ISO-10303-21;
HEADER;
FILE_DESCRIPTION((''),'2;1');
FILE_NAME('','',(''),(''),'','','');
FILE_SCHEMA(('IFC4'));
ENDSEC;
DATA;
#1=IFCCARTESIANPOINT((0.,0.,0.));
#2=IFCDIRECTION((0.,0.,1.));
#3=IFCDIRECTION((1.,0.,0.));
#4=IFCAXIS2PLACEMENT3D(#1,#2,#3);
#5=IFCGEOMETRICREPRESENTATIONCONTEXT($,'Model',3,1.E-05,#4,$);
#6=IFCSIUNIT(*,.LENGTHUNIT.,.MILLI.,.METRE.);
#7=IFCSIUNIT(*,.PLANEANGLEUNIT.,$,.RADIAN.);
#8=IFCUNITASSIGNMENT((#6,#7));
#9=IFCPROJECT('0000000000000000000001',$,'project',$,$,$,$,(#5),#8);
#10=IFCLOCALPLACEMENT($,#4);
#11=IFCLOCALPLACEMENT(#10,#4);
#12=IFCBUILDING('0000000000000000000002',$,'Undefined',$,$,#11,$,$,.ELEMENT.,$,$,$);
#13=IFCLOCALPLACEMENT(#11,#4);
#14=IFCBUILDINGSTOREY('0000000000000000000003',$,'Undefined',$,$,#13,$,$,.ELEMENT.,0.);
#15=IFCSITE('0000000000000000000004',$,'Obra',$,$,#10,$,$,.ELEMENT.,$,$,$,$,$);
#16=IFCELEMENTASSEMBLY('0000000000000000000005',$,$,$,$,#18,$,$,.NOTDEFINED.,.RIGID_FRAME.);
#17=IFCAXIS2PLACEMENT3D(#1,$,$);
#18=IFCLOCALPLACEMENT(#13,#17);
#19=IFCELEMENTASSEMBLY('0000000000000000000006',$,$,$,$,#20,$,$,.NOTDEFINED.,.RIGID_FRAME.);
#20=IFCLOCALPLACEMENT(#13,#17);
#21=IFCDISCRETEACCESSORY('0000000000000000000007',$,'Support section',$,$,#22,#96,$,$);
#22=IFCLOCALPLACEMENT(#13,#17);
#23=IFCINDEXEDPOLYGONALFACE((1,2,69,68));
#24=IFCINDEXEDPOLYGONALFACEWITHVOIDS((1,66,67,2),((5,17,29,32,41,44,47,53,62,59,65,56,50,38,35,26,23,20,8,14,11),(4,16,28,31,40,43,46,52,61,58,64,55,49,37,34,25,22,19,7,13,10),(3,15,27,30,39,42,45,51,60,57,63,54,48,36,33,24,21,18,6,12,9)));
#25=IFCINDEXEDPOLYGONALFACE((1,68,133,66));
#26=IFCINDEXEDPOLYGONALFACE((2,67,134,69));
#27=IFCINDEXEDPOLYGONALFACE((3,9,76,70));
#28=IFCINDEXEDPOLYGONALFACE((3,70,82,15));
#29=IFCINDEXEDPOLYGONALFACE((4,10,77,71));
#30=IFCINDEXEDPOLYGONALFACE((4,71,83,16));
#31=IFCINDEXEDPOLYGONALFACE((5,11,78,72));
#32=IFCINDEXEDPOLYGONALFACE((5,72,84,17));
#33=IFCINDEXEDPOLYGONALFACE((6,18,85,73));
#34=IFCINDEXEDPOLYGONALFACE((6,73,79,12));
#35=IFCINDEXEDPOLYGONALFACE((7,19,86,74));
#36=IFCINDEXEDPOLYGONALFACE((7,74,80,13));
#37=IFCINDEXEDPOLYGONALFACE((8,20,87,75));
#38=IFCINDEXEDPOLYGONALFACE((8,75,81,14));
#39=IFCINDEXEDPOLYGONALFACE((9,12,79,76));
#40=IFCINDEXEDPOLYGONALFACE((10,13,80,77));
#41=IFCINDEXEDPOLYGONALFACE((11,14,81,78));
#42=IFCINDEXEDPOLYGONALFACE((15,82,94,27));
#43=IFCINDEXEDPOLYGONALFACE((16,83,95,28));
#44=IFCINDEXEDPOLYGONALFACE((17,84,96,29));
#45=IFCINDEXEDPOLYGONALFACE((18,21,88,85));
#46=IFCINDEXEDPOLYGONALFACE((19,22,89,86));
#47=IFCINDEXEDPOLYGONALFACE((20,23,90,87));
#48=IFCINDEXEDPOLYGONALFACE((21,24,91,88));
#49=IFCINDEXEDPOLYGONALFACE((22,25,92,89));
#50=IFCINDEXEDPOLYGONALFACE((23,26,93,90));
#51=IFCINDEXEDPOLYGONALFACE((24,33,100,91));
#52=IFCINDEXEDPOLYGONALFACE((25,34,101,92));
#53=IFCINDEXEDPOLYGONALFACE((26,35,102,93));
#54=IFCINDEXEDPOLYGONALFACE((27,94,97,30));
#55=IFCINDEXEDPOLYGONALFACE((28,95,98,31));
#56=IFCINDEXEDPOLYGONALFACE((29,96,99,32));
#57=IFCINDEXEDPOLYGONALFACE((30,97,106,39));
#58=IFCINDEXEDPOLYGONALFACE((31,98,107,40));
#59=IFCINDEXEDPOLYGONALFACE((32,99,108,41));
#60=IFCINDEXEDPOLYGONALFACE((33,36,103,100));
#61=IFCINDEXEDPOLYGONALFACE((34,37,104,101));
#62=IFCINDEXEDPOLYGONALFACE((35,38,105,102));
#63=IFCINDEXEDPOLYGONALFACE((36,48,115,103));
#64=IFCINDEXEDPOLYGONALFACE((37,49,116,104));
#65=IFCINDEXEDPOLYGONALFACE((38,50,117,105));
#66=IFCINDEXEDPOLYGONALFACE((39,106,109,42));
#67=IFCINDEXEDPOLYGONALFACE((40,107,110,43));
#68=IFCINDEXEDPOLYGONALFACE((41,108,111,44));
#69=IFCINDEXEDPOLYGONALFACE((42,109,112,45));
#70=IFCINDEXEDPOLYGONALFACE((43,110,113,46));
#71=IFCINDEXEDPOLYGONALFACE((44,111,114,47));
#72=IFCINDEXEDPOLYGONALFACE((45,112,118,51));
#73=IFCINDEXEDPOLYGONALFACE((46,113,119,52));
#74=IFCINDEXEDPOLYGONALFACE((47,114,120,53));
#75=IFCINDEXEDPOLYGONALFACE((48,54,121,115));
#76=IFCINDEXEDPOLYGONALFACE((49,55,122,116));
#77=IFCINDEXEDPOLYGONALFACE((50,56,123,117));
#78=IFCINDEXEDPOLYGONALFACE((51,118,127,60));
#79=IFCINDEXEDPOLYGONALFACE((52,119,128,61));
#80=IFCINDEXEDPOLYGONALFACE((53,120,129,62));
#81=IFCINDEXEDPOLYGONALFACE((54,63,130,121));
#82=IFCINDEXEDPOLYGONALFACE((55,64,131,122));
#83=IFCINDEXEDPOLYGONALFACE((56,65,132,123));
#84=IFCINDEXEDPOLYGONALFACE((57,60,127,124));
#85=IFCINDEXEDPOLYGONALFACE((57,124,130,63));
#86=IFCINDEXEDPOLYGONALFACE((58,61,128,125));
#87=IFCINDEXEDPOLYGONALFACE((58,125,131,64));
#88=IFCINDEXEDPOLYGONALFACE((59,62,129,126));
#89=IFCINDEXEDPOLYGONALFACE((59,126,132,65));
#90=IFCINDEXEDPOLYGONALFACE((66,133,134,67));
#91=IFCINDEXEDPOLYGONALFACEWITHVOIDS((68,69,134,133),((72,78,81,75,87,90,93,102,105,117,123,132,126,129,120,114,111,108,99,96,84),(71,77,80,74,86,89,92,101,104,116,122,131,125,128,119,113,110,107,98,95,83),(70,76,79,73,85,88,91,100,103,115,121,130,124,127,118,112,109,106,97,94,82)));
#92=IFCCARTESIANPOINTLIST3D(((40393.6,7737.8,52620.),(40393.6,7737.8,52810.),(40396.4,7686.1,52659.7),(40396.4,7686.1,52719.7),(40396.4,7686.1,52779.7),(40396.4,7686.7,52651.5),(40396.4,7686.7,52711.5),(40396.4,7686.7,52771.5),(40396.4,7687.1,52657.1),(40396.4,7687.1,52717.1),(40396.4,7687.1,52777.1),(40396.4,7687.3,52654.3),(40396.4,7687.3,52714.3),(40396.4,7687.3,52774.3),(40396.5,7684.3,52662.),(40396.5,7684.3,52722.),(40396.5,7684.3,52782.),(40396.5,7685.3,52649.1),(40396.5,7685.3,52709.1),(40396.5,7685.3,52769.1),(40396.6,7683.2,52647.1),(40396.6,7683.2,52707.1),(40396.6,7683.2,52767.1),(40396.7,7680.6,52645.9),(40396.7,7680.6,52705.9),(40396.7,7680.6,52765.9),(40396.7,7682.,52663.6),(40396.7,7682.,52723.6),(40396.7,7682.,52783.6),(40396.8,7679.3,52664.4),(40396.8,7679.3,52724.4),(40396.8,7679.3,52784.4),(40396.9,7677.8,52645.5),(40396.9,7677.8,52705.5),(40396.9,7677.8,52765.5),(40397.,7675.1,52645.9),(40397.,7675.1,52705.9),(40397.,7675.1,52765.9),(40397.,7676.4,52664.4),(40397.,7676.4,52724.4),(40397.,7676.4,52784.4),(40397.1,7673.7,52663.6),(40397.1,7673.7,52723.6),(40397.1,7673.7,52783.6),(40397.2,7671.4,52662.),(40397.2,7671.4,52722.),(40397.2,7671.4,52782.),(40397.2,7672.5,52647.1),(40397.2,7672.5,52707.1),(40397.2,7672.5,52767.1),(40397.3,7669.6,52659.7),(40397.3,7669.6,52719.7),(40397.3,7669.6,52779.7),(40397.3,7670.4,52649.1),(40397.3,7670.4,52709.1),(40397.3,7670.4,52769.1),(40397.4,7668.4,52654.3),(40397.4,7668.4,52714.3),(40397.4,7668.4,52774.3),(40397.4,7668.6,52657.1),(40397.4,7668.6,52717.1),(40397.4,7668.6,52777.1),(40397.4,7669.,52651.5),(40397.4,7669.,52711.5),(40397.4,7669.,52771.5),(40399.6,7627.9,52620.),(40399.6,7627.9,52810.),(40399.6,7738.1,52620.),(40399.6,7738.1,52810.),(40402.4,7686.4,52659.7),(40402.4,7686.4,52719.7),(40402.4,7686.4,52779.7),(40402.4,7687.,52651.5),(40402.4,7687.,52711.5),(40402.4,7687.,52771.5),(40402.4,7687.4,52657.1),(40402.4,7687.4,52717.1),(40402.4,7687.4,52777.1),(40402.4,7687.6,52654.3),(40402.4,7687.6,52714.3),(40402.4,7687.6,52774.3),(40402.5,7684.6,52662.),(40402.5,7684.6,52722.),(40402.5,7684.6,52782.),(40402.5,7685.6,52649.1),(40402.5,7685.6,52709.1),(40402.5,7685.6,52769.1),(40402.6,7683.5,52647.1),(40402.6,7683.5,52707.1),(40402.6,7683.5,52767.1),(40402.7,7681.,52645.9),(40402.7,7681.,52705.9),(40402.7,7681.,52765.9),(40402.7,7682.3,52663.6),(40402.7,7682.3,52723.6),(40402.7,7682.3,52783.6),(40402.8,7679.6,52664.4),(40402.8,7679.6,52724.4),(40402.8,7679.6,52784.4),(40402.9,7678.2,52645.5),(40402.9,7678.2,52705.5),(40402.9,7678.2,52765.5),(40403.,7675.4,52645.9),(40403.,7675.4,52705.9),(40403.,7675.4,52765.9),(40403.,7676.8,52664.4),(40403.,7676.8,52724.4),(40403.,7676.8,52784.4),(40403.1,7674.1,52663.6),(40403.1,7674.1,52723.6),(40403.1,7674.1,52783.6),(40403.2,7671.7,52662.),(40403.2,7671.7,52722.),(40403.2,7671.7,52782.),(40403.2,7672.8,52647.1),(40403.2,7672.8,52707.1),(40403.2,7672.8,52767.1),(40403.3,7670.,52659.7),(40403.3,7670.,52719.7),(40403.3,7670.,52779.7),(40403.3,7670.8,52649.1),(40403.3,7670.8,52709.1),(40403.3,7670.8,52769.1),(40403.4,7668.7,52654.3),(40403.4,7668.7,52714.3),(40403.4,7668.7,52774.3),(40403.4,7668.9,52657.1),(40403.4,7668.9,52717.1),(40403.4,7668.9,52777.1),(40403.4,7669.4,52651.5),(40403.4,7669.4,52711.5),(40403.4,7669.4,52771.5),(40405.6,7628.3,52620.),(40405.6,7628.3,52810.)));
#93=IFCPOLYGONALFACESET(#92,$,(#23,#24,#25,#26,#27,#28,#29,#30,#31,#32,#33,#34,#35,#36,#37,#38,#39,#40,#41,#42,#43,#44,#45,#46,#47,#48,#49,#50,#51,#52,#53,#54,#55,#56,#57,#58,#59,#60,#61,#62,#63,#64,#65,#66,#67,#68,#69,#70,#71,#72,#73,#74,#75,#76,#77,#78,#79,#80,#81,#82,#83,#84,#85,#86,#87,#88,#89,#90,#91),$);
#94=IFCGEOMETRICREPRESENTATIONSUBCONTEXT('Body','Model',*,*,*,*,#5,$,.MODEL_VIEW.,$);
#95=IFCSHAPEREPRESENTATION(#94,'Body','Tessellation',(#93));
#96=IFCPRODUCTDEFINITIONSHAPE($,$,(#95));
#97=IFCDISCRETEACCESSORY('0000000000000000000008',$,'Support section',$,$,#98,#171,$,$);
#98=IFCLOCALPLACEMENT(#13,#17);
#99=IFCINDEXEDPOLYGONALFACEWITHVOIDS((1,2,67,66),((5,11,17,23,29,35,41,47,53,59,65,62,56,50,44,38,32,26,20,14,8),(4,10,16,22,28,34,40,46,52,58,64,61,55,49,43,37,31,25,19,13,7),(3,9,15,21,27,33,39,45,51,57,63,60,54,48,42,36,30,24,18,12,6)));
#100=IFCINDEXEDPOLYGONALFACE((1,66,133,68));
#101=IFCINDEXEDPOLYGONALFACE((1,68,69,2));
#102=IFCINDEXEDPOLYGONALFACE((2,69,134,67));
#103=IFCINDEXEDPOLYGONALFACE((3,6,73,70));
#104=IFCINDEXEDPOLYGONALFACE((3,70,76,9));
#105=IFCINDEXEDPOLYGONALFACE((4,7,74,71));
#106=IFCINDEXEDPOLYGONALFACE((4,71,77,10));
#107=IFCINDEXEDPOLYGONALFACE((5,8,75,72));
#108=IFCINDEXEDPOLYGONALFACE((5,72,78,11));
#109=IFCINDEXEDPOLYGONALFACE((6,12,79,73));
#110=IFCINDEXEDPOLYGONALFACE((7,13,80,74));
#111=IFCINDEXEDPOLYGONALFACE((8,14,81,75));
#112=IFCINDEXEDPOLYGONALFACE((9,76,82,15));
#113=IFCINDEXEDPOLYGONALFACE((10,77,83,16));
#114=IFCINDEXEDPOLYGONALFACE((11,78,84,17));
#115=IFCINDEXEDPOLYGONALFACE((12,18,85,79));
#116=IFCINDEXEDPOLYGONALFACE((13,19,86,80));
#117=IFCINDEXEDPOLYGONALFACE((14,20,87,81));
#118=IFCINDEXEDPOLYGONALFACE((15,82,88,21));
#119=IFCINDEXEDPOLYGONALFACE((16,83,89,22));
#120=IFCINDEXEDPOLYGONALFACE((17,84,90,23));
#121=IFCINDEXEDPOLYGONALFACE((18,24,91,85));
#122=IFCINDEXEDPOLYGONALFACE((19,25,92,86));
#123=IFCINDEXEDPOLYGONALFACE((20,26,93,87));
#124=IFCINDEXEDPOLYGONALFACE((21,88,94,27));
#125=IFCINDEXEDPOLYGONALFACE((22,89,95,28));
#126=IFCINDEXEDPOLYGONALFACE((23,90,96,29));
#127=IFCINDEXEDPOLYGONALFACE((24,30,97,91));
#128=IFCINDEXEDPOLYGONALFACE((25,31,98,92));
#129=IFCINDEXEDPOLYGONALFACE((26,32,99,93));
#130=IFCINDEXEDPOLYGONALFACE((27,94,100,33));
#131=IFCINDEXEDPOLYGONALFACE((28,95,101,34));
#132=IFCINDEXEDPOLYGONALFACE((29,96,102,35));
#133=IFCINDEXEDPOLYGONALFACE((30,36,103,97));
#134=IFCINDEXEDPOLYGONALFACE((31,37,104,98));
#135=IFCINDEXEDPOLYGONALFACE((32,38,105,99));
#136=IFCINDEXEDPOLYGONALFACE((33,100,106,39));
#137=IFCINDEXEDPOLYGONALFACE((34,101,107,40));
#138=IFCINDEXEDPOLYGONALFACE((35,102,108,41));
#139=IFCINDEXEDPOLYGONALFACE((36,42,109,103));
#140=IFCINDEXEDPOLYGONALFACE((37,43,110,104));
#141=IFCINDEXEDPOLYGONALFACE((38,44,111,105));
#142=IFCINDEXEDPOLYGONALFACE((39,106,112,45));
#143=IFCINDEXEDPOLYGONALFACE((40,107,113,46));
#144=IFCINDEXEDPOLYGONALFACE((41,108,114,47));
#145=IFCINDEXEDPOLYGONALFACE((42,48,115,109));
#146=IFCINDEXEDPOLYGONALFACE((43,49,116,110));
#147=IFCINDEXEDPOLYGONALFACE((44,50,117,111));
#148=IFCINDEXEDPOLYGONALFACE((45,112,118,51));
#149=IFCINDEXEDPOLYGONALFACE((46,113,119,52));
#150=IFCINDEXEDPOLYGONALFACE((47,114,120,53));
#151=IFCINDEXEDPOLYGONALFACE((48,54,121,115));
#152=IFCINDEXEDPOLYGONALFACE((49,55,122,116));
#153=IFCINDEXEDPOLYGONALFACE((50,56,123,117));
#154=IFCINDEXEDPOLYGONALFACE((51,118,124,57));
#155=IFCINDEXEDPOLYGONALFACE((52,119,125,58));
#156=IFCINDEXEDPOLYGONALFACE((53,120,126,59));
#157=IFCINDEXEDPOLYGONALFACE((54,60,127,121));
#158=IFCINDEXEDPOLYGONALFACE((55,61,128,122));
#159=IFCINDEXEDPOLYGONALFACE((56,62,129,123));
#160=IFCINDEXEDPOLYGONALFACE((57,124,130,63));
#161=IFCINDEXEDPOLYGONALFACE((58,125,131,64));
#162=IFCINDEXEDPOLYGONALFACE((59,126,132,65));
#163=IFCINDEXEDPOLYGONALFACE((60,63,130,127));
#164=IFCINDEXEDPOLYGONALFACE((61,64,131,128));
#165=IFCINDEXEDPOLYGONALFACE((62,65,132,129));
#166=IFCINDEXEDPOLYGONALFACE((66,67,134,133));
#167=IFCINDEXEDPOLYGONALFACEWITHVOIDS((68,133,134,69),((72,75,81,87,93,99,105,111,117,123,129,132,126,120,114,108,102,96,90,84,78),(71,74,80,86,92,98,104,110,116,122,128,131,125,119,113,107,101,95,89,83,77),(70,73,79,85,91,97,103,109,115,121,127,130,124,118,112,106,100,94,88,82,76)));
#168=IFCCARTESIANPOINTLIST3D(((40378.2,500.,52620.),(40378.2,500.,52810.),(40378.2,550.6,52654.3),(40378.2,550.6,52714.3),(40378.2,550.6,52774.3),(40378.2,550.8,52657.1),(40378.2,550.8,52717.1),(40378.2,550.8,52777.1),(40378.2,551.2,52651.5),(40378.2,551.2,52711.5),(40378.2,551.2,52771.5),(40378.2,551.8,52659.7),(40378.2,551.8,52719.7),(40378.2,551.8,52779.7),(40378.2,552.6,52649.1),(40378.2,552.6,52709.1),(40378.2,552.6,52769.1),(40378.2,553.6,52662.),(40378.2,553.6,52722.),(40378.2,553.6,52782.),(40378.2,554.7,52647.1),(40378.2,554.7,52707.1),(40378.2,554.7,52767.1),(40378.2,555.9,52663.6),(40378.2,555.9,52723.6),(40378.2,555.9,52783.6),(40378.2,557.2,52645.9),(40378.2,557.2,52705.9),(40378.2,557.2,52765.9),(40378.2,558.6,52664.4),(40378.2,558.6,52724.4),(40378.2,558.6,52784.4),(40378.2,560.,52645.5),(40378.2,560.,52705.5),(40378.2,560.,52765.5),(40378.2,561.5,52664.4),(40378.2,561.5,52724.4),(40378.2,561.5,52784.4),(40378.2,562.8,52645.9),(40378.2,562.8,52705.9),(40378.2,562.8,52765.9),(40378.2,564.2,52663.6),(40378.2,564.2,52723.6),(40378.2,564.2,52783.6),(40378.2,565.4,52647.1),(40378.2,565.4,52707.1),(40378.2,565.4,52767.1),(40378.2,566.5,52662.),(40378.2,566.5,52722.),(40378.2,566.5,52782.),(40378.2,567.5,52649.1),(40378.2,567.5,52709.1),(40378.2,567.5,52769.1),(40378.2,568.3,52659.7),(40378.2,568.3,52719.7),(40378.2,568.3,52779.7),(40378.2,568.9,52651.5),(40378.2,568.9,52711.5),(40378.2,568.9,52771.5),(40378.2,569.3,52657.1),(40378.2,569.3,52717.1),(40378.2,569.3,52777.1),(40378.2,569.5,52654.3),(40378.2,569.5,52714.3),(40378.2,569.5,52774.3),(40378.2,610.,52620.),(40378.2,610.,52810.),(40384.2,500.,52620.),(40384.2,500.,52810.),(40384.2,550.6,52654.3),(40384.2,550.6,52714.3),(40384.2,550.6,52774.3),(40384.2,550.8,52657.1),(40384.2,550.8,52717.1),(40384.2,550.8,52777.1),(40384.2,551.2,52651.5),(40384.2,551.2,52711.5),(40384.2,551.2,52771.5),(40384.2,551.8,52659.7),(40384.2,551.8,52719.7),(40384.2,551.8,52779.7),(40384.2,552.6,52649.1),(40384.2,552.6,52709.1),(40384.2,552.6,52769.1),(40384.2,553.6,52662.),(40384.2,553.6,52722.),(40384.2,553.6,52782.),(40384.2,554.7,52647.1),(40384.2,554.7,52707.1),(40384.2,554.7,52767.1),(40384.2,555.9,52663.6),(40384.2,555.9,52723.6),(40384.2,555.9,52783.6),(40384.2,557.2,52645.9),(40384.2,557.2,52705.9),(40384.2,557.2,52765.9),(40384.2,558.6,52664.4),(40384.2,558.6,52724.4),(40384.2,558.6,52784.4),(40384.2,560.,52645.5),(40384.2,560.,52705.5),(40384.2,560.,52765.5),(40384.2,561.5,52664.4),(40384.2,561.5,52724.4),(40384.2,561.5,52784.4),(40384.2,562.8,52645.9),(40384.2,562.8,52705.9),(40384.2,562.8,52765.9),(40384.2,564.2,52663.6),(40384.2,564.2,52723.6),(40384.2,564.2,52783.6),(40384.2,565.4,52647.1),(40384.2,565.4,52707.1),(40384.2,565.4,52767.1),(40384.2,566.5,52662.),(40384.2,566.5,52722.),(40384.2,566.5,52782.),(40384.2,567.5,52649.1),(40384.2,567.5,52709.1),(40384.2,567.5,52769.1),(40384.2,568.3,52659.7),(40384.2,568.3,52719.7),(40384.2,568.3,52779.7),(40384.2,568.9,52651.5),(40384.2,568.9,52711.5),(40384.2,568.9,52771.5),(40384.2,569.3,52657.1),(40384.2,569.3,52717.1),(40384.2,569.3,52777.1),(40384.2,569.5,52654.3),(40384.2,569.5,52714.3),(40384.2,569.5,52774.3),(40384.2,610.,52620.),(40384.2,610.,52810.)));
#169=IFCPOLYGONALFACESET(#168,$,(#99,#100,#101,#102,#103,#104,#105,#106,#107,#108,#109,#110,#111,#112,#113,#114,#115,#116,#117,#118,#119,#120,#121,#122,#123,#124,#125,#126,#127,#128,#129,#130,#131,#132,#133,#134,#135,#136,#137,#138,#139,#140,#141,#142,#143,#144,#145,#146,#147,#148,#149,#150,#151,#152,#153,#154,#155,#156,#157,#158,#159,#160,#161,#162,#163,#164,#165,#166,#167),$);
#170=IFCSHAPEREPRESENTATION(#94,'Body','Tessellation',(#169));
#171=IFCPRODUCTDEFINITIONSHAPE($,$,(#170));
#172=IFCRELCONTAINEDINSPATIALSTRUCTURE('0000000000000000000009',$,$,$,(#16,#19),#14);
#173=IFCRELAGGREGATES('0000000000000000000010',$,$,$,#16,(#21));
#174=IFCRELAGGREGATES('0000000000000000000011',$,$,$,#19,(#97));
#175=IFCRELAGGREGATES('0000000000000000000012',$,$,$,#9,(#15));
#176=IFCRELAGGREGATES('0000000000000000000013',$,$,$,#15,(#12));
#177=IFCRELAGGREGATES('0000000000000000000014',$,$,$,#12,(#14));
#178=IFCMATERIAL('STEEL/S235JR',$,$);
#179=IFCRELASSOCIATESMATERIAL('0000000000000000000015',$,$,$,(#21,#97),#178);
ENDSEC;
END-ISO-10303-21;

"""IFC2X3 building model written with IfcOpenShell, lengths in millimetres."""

from ifc_helpers import new_model, si_unit, frame, origin_with_axes, origin_2d_with_axis, place, context, subcontext, project, spatial, rectangle, circle, extrude, source, transform, mapped, material, element, aggregate, save


model = new_model("IFC2X3")

# Units and contexts
model_context = context("Model", 3, precision=1e-05, world=origin_with_axes())
body_context = subcontext(model_context, "Body", "Model", "MODEL_VIEW")
ifc_project = project(units=[si_unit("LENGTHUNIT", "METRE", prefix="MILLI"), si_unit("PLANEANGLEUNIT", "RADIAN")], contexts=[model_context])

# Site, building, storey
site_placement = place(None, origin_with_axes())
site = spatial("IfcSite", under=ifc_project, at=site_placement, Name="Obra", CompositionType="ELEMENT")
building_placement = place(site_placement, origin_with_axes())
building = spatial("IfcBuilding", under=site, at=building_placement, Name="Undefined", CompositionType="ELEMENT")
storey_placement = place(building_placement, origin_with_axes())
storey = spatial("IfcBuildingStorey", under=building, at=storey_placement, Name="Undefined", CompositionType="ELEMENT", Elevation=0.0)

# Element assemblies
ifc_material_1 = material(Name="STEEL/S235JR")
assembly_1_placement = place(storey_placement, origin_with_axes())
assembly_1 = element("IfcElementAssembly", 1, at=assembly_1_placement, inside=storey, AssemblyPlace="NOTDEFINED", PredefinedType="RIGID_FRAME")
assembly_2_placement = place(storey_placement, origin_with_axes())
assembly_2 = element("IfcElementAssembly", 2, at=assembly_2_placement, inside=storey, AssemblyPlace="NOTDEFINED", PredefinedType="RIGID_FRAME")

# Discrete accessories, openings
discrete_accessory_1_placement = place(assembly_1_placement, frame((40399.6, 7683.0, 52620.0), z_axis=(0.0, 0.0, 1.0), x_axis=(-0.055152, 0.998478, 0.0)))
discrete_accessory_1 = element("IfcDiscreteAccessory", 3, at=discrete_accessory_1_placement, material=ifc_material_1, Name="Support section", context=body_context, shape_type="SweptSolid", body=[
    extrude(rectangle(XDim=6.0, YDim=110.0, at=origin_2d_with_axis()), frame((0.0, 0.0, 190.0), z_axis=(0.0, 0.0, -1.0), x_axis=(0.0, 1.0, 0.0)), (0.0, 0.0, 1.0), 190.0),
])
shared_shape_1 = source(origin_with_axes(), body_context, "Body", "SweptSolid", [
    extrude(circle(Radius=9.5, at=origin_2d_with_axis()), frame((0.0, -9.2, 0.0), z_axis=(0.0, 1.0, 0.0), x_axis=(1.0, 0.0, 0.0)), (0.0, 0.0, 1.0), 6.2),
])
opening_1_placement = place(assembly_1_placement, frame((40403.2, 7728.3, 52835.0), z_axis=(0.055152, -0.998478, 0.0), x_axis=(0.0, 0.0, -1.0)))
element("IfcOpeningElement", 4, at=opening_1_placement, cuts=discrete_accessory_1, ObjectType="Opening", context=body_context, shape_type="MappedRepresentation", body=[
    mapped(shared_shape_1, transform((60.0, 0.0, 50.0))),
    mapped(shared_shape_1, transform((120.0, 0.0, 50.0))),
    mapped(shared_shape_1, transform((180.0, 0.0, 50.0))),
])
aggregate(assembly_1, [discrete_accessory_1])
discrete_accessory_2_placement = place(assembly_2_placement, frame((40381.2, 555.0, 52620.0), z_axis=(0.0, 0.0, 1.0), x_axis=(0.000002, -1.0, 0.0)))
discrete_accessory_2 = element("IfcDiscreteAccessory", 5, at=discrete_accessory_2_placement, material=ifc_material_1, Name="Support section", context=body_context, shape_type="SweptSolid", body=[
    extrude(rectangle(XDim=6.0, YDim=110.0, at=origin_2d_with_axis()), frame((0.0, 0.0, 190.0), z_axis=(0.0, 0.0, -1.0), x_axis=(0.0, 1.0, 0.0)), (0.0, 0.0, 1.0), 190.0),
])
opening_2_placement = place(assembly_2_placement, frame((40375.1, 510.0, 52835.0), z_axis=(-0.000002, 1.0, 0.0), x_axis=(0.0, 0.0, -1.0)))
element("IfcOpeningElement", 6, at=opening_2_placement, cuts=discrete_accessory_2, ObjectType="Opening", context=body_context, shape_type="MappedRepresentation", body=[
    mapped(shared_shape_1, transform((60.0, 0.0, 50.0))),
    mapped(shared_shape_1, transform((120.0, 0.0, 50.0))),
    mapped(shared_shape_1, transform((180.0, 0.0, 50.0))),
])
aggregate(assembly_2, [discrete_accessory_2])

save(model, "model.ifc")
